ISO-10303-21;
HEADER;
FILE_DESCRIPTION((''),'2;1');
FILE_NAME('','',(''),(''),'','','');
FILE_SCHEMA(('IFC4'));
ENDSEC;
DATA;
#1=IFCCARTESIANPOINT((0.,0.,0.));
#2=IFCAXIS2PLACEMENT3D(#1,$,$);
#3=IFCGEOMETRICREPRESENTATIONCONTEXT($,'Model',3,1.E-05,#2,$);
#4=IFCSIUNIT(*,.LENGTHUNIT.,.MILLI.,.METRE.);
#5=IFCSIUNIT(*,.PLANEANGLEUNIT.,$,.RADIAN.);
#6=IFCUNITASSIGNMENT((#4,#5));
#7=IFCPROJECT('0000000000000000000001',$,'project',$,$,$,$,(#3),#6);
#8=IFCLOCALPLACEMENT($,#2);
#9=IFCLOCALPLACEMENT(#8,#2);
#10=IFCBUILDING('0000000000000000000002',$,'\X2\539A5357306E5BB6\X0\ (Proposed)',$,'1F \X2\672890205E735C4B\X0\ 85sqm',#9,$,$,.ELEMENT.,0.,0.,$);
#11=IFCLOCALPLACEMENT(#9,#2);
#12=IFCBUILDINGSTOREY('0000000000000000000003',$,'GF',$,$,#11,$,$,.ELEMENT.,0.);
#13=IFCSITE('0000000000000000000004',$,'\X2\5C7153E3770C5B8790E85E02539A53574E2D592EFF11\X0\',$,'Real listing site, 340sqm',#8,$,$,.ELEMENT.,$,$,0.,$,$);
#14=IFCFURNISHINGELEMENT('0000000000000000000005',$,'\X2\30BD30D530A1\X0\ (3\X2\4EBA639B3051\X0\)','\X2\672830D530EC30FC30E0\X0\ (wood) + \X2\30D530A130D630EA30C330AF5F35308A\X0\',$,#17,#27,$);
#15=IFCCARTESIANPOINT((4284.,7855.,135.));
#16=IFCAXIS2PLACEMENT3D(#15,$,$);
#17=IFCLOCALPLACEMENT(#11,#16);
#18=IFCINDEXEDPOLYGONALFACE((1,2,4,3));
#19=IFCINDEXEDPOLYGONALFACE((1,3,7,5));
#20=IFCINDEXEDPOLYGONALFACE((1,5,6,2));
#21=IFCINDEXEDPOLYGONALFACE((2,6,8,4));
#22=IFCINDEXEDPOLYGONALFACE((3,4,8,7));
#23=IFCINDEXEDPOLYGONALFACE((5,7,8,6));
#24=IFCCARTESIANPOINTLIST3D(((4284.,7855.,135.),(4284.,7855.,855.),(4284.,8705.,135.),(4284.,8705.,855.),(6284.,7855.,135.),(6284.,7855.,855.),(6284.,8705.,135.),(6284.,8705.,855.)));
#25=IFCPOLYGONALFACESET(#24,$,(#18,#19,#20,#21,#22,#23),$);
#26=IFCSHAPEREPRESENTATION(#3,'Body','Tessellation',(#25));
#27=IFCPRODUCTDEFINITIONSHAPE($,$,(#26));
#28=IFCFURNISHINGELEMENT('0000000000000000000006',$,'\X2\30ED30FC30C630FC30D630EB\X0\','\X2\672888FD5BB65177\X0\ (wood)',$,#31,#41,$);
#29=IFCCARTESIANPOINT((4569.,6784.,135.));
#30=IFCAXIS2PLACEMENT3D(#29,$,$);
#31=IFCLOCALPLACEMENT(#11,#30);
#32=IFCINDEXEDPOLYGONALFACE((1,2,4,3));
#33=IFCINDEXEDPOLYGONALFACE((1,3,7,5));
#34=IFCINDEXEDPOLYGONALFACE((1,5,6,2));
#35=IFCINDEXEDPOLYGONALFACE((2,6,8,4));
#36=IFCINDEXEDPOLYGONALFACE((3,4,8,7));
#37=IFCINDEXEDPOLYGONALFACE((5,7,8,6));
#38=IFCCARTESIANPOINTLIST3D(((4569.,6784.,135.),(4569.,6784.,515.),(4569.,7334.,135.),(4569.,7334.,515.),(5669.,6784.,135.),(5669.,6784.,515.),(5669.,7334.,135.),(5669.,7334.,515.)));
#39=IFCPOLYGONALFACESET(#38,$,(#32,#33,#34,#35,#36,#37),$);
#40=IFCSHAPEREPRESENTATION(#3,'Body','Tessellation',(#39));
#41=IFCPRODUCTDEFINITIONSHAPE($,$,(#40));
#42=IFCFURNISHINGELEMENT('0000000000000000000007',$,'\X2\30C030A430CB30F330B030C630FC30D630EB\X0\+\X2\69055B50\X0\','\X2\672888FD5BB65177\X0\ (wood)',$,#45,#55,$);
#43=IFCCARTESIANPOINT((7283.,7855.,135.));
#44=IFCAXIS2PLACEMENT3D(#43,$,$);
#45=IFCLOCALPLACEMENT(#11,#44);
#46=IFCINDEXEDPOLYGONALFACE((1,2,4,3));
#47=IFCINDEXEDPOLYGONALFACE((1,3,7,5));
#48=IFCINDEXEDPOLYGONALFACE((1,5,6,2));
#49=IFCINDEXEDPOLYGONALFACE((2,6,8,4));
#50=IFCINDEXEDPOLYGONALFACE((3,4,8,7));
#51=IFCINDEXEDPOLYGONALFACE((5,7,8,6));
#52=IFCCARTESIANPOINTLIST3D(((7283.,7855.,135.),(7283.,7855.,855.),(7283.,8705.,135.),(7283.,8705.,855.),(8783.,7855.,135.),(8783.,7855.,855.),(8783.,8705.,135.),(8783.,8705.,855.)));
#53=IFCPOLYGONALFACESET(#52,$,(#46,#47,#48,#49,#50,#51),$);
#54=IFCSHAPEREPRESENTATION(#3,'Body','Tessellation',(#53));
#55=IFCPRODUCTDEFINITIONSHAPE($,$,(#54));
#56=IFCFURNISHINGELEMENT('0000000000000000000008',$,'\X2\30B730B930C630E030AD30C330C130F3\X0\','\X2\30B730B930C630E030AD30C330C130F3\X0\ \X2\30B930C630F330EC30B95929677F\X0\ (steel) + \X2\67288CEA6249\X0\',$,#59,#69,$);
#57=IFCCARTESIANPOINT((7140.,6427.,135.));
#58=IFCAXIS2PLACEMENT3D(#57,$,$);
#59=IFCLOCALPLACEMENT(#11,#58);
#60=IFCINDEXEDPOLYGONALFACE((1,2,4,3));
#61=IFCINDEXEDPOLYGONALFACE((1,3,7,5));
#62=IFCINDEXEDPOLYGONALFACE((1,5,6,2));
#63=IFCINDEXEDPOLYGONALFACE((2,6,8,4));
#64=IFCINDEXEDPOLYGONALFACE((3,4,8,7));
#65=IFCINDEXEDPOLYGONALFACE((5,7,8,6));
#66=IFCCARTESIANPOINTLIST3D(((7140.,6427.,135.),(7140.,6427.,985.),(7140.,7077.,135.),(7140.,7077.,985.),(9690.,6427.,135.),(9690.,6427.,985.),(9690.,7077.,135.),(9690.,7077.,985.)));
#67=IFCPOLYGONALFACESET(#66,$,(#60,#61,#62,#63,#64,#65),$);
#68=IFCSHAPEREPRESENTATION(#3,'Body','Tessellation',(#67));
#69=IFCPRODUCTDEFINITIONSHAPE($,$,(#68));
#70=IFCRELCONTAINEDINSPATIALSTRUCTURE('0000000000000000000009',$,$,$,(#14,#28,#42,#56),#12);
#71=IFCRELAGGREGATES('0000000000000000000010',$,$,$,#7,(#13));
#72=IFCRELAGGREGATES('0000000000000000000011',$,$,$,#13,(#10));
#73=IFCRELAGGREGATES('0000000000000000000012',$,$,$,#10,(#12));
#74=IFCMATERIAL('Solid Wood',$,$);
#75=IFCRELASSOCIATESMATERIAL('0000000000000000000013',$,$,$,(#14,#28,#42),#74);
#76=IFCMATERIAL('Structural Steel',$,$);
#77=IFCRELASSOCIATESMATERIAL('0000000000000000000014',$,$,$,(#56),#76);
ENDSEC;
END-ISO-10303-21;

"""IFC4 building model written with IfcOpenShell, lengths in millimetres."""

from ifc_helpers import new_model, si_unit, frame, frame_2d, origin, place, context, project, spatial, rectangle, extrude, material, element, save


model = new_model("IFC4")

# Units and contexts
model_context = context("Model", 3, precision=1e-05, world=origin())
ifc_project = project(units=[si_unit("LENGTHUNIT", "METRE", prefix="MILLI"), si_unit("PLANEANGLEUNIT", "RADIAN")], contexts=[model_context])

# Site, building, storey
site_placement = place(None, origin())
site = spatial("IfcSite", under=ifc_project, at=site_placement, Name="山口県宇部市厚南中央１", ObjectType="Real listing site, 340sqm", CompositionType="ELEMENT", RefElevation=0.0)
building_placement = place(site_placement, origin())
building = spatial("IfcBuilding", under=site, at=building_placement, Name="厚南の家 (Proposed)", ObjectType="1F 木造平屋 85sqm", CompositionType="ELEMENT", ElevationOfRefHeight=0.0, ElevationOfTerrain=0.0)
storey_placement = place(building_placement, origin())
storey = spatial("IfcBuildingStorey", under=building, at=storey_placement, Name="GF", CompositionType="ELEMENT", Elevation=0.0)

# Shared definitions
ifc_material_1 = material(Name="Solid Wood")

# Shared definitions
ifc_material_2 = material(Name="Structural Steel")

# Furnishing elements
furnishing_1_placement = place(storey_placement, frame((4284.0, 7855.0, 135.0)))
element("IfcFurnishingElement", 1, at=furnishing_1_placement, inside=storey, material=ifc_material_1, Name="ソファ (3人掛け)", Description="木フレーム (wood) + ファブリック張り", context=model_context, shape_type="SweptSolid", body=[
    extrude(rectangle(XDim=2000.0, YDim=850.0, at=frame_2d((1000.0, 425.0))), frame((4284.0, 7855.0, 135.0)), (0.0, 0.0, 1.0), 720.0),
])
furnishing_2_placement = place(storey_placement, frame((4569.0, 6784.0, 135.0)))
element("IfcFurnishingElement", 2, at=furnishing_2_placement, inside=storey, material=ifc_material_1, Name="ローテーブル", Description="木製家具 (wood)", context=model_context, shape_type="SweptSolid", body=[
    extrude(rectangle(XDim=1100.0, YDim=550.0, at=frame_2d((550.0, 275.0))), frame((4569.0, 6784.0, 135.0)), (0.0, 0.0, 1.0), 380.0),
])
furnishing_3_placement = place(storey_placement, frame((7283.0, 7855.0, 135.0)))
element("IfcFurnishingElement", 3, at=furnishing_3_placement, inside=storey, material=ifc_material_1, Name="ダイニングテーブル+椅子", Description="木製家具 (wood)", context=model_context, shape_type="SweptSolid", body=[
    extrude(rectangle(XDim=1500.0, YDim=850.0, at=frame_2d((750.0, 425.0))), frame((7283.0, 7855.0, 135.0)), (0.0, 0.0, 1.0), 720.0),
])
furnishing_4_placement = place(storey_placement, frame((7140.0, 6427.0, 135.0)))
element("IfcFurnishingElement", 4, at=furnishing_4_placement, inside=storey, material=ifc_material_2, Name="システムキッチン", Description="システムキッチン ステンレス天板 (steel) + 木質扉", context=model_context, shape_type="SweptSolid", body=[
    extrude(rectangle(XDim=2550.0, YDim=650.0, at=frame_2d((1275.0, 325.0))), frame((7140.0, 6427.0, 135.0)), (0.0, 0.0, 1.0), 850.0),
])

save(model, "model.ifc")
